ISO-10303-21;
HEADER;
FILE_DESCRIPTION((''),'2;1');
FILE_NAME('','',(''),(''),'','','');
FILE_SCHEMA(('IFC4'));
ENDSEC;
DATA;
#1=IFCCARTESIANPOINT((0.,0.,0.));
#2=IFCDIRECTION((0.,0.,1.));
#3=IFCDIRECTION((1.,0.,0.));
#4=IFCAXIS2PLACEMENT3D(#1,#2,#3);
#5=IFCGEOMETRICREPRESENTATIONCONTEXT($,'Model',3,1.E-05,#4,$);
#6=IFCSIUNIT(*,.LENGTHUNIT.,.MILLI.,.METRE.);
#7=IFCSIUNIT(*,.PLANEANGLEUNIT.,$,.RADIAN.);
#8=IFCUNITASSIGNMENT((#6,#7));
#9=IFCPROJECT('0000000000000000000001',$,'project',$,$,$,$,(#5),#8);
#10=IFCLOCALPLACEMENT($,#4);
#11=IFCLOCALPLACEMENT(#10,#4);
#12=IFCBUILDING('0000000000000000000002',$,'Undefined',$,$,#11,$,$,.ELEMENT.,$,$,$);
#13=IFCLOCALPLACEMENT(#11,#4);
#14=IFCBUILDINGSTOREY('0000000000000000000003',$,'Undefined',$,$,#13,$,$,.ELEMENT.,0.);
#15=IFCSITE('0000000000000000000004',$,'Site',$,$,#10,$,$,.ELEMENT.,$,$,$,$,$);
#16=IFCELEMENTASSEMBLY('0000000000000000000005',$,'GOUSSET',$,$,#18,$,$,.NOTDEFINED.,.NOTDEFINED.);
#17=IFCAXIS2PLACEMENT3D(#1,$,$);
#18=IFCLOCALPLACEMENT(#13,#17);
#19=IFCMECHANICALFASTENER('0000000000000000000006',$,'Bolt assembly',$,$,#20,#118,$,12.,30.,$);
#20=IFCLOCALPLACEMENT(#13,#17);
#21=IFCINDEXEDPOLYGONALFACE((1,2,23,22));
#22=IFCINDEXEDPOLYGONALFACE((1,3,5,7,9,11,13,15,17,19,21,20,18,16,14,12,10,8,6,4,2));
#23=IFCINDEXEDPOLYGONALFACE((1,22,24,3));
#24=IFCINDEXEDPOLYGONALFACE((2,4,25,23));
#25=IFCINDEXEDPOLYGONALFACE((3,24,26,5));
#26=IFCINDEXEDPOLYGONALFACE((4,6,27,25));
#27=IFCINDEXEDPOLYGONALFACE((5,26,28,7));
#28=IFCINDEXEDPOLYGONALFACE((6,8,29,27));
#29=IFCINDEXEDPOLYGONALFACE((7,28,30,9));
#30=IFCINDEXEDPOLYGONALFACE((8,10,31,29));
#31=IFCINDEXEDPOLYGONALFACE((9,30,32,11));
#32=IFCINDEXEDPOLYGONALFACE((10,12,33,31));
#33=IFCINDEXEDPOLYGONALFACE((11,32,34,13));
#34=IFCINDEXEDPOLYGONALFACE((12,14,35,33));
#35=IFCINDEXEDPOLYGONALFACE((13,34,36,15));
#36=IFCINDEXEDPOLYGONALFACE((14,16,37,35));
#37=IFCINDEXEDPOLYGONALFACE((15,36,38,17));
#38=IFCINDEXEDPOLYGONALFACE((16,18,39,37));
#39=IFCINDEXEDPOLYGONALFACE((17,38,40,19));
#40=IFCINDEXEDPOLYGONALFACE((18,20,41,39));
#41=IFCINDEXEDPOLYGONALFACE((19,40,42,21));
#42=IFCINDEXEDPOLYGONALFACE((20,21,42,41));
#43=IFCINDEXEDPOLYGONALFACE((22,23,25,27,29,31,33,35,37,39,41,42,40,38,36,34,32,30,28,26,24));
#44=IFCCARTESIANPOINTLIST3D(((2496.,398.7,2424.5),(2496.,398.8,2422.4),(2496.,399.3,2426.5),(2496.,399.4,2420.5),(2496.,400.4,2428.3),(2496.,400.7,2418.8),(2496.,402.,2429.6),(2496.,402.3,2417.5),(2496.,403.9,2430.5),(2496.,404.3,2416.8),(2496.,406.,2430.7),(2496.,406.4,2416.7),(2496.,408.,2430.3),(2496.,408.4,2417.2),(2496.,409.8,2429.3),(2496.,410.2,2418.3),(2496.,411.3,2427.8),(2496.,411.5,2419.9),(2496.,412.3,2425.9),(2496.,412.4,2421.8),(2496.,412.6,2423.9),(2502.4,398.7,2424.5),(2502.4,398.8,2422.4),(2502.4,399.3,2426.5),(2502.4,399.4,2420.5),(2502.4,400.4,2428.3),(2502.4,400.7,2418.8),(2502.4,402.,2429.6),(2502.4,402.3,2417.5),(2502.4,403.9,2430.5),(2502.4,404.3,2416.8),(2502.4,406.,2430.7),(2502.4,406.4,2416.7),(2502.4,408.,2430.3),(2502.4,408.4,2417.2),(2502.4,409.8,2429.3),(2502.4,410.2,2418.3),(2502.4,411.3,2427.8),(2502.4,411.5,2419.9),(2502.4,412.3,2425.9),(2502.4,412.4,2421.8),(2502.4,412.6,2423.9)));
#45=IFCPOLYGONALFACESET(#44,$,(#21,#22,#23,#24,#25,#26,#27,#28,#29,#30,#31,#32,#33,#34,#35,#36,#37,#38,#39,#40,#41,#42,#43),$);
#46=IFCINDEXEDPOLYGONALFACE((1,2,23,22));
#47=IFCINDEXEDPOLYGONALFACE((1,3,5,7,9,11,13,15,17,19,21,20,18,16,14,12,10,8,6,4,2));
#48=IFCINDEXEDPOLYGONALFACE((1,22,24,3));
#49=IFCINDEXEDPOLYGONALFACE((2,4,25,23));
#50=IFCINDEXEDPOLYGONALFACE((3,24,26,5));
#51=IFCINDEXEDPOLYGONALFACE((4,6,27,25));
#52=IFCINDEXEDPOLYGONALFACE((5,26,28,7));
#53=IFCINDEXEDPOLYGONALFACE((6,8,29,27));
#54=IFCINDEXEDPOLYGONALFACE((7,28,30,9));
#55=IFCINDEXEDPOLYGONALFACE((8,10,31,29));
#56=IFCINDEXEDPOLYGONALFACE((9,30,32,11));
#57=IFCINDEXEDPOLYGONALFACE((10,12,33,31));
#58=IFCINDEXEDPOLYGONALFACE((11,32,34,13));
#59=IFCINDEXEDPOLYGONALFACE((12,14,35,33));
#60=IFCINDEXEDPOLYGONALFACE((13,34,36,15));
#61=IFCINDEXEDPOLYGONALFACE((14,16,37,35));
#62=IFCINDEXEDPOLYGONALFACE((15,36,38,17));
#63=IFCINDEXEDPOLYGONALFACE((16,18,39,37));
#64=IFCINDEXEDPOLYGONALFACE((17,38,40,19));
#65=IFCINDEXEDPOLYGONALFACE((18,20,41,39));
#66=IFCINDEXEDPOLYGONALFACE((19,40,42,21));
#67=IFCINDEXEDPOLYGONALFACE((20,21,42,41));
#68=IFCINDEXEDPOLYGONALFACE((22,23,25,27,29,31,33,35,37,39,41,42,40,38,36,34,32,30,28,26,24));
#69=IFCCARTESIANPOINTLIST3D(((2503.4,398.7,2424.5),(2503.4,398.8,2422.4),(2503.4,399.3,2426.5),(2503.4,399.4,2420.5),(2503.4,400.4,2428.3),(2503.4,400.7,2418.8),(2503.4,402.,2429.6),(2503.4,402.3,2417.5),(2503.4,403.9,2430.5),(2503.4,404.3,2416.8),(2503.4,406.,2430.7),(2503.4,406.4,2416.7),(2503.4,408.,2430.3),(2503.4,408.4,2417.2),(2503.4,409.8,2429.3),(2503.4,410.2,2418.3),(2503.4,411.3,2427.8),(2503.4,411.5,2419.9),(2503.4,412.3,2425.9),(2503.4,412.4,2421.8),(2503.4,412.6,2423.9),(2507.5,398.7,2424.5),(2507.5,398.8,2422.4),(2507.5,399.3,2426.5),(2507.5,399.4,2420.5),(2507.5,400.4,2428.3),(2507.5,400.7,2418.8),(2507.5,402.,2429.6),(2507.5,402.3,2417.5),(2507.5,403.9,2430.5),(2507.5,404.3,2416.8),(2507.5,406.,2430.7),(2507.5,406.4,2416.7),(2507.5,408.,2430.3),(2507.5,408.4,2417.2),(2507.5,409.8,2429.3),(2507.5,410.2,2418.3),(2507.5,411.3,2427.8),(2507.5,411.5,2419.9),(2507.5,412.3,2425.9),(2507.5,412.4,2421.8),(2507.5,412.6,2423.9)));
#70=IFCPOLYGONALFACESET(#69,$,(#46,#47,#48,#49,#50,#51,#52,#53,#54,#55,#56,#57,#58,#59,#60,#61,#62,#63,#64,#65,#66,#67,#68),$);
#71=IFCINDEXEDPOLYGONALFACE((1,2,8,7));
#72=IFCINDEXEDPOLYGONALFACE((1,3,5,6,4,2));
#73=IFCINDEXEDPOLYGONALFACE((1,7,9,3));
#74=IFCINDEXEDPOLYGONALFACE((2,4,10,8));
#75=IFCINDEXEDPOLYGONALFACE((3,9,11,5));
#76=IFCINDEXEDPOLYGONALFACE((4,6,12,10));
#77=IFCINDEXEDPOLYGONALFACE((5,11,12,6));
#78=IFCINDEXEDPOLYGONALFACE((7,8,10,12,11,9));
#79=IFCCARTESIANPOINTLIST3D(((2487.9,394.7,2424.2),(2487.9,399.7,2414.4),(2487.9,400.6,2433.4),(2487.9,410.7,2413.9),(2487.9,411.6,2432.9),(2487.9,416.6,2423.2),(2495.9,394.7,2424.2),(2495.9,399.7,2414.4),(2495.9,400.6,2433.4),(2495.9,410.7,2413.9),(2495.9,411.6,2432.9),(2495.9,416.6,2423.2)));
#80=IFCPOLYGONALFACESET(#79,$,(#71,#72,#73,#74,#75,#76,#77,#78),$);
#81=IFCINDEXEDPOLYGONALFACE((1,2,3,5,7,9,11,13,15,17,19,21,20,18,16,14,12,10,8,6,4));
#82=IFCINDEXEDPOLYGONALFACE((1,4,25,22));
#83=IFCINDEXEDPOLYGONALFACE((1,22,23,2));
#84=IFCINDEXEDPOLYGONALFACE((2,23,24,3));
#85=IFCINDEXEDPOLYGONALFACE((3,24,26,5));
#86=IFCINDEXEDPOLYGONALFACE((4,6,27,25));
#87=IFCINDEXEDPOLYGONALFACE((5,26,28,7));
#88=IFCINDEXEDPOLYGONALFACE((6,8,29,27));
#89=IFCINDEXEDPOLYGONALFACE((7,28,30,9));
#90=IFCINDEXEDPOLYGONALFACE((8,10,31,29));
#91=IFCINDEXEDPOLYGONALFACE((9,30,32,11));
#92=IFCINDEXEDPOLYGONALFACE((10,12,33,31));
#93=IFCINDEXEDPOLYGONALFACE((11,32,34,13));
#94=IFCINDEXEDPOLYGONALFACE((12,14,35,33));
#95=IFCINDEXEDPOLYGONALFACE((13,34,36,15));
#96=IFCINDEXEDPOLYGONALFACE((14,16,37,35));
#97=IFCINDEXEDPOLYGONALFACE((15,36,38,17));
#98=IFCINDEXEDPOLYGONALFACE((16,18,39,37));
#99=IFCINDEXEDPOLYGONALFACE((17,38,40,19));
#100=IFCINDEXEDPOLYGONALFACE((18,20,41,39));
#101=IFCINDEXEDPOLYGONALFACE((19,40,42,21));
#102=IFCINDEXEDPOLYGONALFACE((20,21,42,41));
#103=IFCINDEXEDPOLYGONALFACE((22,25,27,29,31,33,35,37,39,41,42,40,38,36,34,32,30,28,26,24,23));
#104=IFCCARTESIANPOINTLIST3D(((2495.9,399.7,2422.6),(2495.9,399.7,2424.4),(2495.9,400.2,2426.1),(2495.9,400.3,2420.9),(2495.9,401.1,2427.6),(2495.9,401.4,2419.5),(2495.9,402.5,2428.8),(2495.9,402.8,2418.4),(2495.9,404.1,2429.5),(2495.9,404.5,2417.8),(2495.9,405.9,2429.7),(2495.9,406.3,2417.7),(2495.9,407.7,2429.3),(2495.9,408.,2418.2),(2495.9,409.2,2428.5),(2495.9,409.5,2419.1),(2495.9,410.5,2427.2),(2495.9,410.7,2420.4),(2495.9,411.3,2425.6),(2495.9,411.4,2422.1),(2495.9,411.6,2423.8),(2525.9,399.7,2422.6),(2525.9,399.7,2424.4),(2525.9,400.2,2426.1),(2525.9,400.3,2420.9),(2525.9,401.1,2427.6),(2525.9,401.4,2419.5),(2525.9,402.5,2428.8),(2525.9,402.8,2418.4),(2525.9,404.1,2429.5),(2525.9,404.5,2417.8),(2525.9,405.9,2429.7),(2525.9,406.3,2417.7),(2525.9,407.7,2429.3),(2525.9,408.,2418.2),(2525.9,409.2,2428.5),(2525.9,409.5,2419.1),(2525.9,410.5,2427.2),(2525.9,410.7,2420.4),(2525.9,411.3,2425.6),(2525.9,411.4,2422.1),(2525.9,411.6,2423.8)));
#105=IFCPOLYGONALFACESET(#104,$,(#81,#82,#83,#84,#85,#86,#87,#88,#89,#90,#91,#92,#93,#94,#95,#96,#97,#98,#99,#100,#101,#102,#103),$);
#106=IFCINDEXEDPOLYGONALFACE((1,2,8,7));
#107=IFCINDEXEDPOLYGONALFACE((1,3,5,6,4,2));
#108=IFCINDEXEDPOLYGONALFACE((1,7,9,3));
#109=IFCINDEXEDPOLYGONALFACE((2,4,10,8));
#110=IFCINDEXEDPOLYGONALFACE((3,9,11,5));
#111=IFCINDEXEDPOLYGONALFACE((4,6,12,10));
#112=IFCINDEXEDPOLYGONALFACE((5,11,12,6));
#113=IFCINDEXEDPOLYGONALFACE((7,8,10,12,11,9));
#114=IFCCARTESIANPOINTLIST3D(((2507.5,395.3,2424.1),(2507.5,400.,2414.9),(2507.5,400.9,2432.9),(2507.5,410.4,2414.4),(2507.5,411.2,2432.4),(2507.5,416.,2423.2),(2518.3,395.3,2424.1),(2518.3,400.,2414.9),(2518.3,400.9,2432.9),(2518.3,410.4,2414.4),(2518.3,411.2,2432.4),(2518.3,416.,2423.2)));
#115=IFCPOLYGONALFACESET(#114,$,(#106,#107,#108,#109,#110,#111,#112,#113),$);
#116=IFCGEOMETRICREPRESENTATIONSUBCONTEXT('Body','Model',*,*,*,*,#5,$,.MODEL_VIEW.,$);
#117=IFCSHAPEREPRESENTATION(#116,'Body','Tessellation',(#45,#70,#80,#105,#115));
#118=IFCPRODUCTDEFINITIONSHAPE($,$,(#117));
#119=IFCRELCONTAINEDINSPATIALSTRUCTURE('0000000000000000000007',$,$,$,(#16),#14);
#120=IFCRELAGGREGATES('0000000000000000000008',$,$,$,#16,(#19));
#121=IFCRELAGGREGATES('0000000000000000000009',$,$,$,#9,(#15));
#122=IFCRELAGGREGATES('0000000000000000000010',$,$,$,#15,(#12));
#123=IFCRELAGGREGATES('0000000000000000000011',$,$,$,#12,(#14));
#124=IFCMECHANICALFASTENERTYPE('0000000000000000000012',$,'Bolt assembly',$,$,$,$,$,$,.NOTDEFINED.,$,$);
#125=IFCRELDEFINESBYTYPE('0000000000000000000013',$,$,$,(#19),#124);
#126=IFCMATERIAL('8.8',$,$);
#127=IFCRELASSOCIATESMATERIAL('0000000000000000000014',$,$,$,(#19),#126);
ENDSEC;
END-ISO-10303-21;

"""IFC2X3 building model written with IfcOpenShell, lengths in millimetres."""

from ifc_helpers import new_model, si_unit, frame, origin_with_axes, origin_2d_with_axis, place, context, subcontext, project, spatial, polyline, circle, outline, extrude, source, transform, mapped, material, type_object, element, aggregate, save


model = new_model("IFC2X3")

# Units and contexts
model_context = context("Model", 3, precision=1e-05, world=origin_with_axes())
body_context = subcontext(model_context, "Body", "Model", "MODEL_VIEW")
ifc_project = project(units=[si_unit("LENGTHUNIT", "METRE", prefix="MILLI"), si_unit("PLANEANGLEUNIT", "RADIAN")], contexts=[model_context])

# Site, building, storey
site_placement = place(None, origin_with_axes())
site = spatial("IfcSite", under=ifc_project, at=site_placement, Name="Site", CompositionType="ELEMENT")
building_placement = place(site_placement, origin_with_axes())
building = spatial("IfcBuilding", under=site, at=building_placement, Name="Undefined", CompositionType="ELEMENT")
storey_placement = place(building_placement, origin_with_axes())
storey = spatial("IfcBuildingStorey", under=building, at=storey_placement, Name="Undefined", CompositionType="ELEMENT", Elevation=0.0)

# Element assembly
assembly_1_placement = place(storey_placement, origin_with_axes())
assembly_1 = element("IfcElementAssembly", 1, at=assembly_1_placement, inside=storey, Name="GOUSSET", AssemblyPlace="NOTDEFINED", PredefinedType="NOTDEFINED")

# Shared definitions
ifc_material_1 = material(Name="8.8")
mechanical_fastener_type = type_object("IfcMechanicalFastenerType", Name="Bolt assembly")

# Mechanical fastener
shared_shape_1 = source(origin_with_axes(), body_context, "Body", "SweptSolid", [
    extrude(circle(Radius=7.0, at=origin_2d_with_axis()), frame((0.0, -23.5, 0.0), z_axis=(0.0, 1.0, 0.0), x_axis=(1.0, 0.0, 0.0)), (0.0, 0.0, 1.0), 6.3),
    extrude(circle(Radius=7.0, at=origin_2d_with_axis()), frame((0.0, -16.1, 0.0), z_axis=(0.0, 1.0, 0.0), x_axis=(1.0, 0.0, 0.0)), (0.0, 0.0, 1.0), 4.1),
    extrude(outline(polyline([(9.5, -5.5), (9.5, 5.5), (0.0, 11.0), (-9.5, 5.5), (-9.5, -5.5), (0.0, -11.0), (9.5, -5.5)])), frame((0.0, -31.6, 0.0), z_axis=(0.0, 1.0, 0.0), x_axis=(1.0, 0.0, 0.0)), (0.0, 0.0, 1.0), 8.0),
    extrude(circle(Radius=6.0, at=origin_2d_with_axis()), frame((0.0, -23.6, 0.0), z_axis=(0.0, 1.0, 0.0), x_axis=(1.0, 0.0, 0.0)), (0.0, 0.0, 1.0), 30.0),
    extrude(outline(polyline([(9.0, -5.2), (9.0, 5.2), (0.0, 10.4), (-9.0, 5.2), (-9.0, -5.2), (0.0, -10.4), (9.0, -5.2)])), frame((0.0, -12.0, 0.0), z_axis=(0.0, 1.0, 0.0), x_axis=(1.0, 0.0, 0.0)), (0.0, 0.0, 1.0), 10.8),
])
mechanical_fastener_1_placement = place(assembly_1_placement, frame((2519.5, 405.6, 2423.7), z_axis=(0.0, -0.459948, 0.887946), x_axis=(-0.000006, -0.887946, -0.459948)))
mechanical_fastener_1 = element("IfcMechanicalFastener", 2, at=mechanical_fastener_1_placement, type_object=mechanical_fastener_type, material=ifc_material_1, Name="Bolt assembly", NominalDiameter=12.0, NominalLength=30.0, context=body_context, shape_type="MappedRepresentation", body=[
    mapped(shared_shape_1, transform((0.0, 0.0, 0.0))),
])
aggregate(assembly_1, [mechanical_fastener_1])

save(model, "model.ifc")
